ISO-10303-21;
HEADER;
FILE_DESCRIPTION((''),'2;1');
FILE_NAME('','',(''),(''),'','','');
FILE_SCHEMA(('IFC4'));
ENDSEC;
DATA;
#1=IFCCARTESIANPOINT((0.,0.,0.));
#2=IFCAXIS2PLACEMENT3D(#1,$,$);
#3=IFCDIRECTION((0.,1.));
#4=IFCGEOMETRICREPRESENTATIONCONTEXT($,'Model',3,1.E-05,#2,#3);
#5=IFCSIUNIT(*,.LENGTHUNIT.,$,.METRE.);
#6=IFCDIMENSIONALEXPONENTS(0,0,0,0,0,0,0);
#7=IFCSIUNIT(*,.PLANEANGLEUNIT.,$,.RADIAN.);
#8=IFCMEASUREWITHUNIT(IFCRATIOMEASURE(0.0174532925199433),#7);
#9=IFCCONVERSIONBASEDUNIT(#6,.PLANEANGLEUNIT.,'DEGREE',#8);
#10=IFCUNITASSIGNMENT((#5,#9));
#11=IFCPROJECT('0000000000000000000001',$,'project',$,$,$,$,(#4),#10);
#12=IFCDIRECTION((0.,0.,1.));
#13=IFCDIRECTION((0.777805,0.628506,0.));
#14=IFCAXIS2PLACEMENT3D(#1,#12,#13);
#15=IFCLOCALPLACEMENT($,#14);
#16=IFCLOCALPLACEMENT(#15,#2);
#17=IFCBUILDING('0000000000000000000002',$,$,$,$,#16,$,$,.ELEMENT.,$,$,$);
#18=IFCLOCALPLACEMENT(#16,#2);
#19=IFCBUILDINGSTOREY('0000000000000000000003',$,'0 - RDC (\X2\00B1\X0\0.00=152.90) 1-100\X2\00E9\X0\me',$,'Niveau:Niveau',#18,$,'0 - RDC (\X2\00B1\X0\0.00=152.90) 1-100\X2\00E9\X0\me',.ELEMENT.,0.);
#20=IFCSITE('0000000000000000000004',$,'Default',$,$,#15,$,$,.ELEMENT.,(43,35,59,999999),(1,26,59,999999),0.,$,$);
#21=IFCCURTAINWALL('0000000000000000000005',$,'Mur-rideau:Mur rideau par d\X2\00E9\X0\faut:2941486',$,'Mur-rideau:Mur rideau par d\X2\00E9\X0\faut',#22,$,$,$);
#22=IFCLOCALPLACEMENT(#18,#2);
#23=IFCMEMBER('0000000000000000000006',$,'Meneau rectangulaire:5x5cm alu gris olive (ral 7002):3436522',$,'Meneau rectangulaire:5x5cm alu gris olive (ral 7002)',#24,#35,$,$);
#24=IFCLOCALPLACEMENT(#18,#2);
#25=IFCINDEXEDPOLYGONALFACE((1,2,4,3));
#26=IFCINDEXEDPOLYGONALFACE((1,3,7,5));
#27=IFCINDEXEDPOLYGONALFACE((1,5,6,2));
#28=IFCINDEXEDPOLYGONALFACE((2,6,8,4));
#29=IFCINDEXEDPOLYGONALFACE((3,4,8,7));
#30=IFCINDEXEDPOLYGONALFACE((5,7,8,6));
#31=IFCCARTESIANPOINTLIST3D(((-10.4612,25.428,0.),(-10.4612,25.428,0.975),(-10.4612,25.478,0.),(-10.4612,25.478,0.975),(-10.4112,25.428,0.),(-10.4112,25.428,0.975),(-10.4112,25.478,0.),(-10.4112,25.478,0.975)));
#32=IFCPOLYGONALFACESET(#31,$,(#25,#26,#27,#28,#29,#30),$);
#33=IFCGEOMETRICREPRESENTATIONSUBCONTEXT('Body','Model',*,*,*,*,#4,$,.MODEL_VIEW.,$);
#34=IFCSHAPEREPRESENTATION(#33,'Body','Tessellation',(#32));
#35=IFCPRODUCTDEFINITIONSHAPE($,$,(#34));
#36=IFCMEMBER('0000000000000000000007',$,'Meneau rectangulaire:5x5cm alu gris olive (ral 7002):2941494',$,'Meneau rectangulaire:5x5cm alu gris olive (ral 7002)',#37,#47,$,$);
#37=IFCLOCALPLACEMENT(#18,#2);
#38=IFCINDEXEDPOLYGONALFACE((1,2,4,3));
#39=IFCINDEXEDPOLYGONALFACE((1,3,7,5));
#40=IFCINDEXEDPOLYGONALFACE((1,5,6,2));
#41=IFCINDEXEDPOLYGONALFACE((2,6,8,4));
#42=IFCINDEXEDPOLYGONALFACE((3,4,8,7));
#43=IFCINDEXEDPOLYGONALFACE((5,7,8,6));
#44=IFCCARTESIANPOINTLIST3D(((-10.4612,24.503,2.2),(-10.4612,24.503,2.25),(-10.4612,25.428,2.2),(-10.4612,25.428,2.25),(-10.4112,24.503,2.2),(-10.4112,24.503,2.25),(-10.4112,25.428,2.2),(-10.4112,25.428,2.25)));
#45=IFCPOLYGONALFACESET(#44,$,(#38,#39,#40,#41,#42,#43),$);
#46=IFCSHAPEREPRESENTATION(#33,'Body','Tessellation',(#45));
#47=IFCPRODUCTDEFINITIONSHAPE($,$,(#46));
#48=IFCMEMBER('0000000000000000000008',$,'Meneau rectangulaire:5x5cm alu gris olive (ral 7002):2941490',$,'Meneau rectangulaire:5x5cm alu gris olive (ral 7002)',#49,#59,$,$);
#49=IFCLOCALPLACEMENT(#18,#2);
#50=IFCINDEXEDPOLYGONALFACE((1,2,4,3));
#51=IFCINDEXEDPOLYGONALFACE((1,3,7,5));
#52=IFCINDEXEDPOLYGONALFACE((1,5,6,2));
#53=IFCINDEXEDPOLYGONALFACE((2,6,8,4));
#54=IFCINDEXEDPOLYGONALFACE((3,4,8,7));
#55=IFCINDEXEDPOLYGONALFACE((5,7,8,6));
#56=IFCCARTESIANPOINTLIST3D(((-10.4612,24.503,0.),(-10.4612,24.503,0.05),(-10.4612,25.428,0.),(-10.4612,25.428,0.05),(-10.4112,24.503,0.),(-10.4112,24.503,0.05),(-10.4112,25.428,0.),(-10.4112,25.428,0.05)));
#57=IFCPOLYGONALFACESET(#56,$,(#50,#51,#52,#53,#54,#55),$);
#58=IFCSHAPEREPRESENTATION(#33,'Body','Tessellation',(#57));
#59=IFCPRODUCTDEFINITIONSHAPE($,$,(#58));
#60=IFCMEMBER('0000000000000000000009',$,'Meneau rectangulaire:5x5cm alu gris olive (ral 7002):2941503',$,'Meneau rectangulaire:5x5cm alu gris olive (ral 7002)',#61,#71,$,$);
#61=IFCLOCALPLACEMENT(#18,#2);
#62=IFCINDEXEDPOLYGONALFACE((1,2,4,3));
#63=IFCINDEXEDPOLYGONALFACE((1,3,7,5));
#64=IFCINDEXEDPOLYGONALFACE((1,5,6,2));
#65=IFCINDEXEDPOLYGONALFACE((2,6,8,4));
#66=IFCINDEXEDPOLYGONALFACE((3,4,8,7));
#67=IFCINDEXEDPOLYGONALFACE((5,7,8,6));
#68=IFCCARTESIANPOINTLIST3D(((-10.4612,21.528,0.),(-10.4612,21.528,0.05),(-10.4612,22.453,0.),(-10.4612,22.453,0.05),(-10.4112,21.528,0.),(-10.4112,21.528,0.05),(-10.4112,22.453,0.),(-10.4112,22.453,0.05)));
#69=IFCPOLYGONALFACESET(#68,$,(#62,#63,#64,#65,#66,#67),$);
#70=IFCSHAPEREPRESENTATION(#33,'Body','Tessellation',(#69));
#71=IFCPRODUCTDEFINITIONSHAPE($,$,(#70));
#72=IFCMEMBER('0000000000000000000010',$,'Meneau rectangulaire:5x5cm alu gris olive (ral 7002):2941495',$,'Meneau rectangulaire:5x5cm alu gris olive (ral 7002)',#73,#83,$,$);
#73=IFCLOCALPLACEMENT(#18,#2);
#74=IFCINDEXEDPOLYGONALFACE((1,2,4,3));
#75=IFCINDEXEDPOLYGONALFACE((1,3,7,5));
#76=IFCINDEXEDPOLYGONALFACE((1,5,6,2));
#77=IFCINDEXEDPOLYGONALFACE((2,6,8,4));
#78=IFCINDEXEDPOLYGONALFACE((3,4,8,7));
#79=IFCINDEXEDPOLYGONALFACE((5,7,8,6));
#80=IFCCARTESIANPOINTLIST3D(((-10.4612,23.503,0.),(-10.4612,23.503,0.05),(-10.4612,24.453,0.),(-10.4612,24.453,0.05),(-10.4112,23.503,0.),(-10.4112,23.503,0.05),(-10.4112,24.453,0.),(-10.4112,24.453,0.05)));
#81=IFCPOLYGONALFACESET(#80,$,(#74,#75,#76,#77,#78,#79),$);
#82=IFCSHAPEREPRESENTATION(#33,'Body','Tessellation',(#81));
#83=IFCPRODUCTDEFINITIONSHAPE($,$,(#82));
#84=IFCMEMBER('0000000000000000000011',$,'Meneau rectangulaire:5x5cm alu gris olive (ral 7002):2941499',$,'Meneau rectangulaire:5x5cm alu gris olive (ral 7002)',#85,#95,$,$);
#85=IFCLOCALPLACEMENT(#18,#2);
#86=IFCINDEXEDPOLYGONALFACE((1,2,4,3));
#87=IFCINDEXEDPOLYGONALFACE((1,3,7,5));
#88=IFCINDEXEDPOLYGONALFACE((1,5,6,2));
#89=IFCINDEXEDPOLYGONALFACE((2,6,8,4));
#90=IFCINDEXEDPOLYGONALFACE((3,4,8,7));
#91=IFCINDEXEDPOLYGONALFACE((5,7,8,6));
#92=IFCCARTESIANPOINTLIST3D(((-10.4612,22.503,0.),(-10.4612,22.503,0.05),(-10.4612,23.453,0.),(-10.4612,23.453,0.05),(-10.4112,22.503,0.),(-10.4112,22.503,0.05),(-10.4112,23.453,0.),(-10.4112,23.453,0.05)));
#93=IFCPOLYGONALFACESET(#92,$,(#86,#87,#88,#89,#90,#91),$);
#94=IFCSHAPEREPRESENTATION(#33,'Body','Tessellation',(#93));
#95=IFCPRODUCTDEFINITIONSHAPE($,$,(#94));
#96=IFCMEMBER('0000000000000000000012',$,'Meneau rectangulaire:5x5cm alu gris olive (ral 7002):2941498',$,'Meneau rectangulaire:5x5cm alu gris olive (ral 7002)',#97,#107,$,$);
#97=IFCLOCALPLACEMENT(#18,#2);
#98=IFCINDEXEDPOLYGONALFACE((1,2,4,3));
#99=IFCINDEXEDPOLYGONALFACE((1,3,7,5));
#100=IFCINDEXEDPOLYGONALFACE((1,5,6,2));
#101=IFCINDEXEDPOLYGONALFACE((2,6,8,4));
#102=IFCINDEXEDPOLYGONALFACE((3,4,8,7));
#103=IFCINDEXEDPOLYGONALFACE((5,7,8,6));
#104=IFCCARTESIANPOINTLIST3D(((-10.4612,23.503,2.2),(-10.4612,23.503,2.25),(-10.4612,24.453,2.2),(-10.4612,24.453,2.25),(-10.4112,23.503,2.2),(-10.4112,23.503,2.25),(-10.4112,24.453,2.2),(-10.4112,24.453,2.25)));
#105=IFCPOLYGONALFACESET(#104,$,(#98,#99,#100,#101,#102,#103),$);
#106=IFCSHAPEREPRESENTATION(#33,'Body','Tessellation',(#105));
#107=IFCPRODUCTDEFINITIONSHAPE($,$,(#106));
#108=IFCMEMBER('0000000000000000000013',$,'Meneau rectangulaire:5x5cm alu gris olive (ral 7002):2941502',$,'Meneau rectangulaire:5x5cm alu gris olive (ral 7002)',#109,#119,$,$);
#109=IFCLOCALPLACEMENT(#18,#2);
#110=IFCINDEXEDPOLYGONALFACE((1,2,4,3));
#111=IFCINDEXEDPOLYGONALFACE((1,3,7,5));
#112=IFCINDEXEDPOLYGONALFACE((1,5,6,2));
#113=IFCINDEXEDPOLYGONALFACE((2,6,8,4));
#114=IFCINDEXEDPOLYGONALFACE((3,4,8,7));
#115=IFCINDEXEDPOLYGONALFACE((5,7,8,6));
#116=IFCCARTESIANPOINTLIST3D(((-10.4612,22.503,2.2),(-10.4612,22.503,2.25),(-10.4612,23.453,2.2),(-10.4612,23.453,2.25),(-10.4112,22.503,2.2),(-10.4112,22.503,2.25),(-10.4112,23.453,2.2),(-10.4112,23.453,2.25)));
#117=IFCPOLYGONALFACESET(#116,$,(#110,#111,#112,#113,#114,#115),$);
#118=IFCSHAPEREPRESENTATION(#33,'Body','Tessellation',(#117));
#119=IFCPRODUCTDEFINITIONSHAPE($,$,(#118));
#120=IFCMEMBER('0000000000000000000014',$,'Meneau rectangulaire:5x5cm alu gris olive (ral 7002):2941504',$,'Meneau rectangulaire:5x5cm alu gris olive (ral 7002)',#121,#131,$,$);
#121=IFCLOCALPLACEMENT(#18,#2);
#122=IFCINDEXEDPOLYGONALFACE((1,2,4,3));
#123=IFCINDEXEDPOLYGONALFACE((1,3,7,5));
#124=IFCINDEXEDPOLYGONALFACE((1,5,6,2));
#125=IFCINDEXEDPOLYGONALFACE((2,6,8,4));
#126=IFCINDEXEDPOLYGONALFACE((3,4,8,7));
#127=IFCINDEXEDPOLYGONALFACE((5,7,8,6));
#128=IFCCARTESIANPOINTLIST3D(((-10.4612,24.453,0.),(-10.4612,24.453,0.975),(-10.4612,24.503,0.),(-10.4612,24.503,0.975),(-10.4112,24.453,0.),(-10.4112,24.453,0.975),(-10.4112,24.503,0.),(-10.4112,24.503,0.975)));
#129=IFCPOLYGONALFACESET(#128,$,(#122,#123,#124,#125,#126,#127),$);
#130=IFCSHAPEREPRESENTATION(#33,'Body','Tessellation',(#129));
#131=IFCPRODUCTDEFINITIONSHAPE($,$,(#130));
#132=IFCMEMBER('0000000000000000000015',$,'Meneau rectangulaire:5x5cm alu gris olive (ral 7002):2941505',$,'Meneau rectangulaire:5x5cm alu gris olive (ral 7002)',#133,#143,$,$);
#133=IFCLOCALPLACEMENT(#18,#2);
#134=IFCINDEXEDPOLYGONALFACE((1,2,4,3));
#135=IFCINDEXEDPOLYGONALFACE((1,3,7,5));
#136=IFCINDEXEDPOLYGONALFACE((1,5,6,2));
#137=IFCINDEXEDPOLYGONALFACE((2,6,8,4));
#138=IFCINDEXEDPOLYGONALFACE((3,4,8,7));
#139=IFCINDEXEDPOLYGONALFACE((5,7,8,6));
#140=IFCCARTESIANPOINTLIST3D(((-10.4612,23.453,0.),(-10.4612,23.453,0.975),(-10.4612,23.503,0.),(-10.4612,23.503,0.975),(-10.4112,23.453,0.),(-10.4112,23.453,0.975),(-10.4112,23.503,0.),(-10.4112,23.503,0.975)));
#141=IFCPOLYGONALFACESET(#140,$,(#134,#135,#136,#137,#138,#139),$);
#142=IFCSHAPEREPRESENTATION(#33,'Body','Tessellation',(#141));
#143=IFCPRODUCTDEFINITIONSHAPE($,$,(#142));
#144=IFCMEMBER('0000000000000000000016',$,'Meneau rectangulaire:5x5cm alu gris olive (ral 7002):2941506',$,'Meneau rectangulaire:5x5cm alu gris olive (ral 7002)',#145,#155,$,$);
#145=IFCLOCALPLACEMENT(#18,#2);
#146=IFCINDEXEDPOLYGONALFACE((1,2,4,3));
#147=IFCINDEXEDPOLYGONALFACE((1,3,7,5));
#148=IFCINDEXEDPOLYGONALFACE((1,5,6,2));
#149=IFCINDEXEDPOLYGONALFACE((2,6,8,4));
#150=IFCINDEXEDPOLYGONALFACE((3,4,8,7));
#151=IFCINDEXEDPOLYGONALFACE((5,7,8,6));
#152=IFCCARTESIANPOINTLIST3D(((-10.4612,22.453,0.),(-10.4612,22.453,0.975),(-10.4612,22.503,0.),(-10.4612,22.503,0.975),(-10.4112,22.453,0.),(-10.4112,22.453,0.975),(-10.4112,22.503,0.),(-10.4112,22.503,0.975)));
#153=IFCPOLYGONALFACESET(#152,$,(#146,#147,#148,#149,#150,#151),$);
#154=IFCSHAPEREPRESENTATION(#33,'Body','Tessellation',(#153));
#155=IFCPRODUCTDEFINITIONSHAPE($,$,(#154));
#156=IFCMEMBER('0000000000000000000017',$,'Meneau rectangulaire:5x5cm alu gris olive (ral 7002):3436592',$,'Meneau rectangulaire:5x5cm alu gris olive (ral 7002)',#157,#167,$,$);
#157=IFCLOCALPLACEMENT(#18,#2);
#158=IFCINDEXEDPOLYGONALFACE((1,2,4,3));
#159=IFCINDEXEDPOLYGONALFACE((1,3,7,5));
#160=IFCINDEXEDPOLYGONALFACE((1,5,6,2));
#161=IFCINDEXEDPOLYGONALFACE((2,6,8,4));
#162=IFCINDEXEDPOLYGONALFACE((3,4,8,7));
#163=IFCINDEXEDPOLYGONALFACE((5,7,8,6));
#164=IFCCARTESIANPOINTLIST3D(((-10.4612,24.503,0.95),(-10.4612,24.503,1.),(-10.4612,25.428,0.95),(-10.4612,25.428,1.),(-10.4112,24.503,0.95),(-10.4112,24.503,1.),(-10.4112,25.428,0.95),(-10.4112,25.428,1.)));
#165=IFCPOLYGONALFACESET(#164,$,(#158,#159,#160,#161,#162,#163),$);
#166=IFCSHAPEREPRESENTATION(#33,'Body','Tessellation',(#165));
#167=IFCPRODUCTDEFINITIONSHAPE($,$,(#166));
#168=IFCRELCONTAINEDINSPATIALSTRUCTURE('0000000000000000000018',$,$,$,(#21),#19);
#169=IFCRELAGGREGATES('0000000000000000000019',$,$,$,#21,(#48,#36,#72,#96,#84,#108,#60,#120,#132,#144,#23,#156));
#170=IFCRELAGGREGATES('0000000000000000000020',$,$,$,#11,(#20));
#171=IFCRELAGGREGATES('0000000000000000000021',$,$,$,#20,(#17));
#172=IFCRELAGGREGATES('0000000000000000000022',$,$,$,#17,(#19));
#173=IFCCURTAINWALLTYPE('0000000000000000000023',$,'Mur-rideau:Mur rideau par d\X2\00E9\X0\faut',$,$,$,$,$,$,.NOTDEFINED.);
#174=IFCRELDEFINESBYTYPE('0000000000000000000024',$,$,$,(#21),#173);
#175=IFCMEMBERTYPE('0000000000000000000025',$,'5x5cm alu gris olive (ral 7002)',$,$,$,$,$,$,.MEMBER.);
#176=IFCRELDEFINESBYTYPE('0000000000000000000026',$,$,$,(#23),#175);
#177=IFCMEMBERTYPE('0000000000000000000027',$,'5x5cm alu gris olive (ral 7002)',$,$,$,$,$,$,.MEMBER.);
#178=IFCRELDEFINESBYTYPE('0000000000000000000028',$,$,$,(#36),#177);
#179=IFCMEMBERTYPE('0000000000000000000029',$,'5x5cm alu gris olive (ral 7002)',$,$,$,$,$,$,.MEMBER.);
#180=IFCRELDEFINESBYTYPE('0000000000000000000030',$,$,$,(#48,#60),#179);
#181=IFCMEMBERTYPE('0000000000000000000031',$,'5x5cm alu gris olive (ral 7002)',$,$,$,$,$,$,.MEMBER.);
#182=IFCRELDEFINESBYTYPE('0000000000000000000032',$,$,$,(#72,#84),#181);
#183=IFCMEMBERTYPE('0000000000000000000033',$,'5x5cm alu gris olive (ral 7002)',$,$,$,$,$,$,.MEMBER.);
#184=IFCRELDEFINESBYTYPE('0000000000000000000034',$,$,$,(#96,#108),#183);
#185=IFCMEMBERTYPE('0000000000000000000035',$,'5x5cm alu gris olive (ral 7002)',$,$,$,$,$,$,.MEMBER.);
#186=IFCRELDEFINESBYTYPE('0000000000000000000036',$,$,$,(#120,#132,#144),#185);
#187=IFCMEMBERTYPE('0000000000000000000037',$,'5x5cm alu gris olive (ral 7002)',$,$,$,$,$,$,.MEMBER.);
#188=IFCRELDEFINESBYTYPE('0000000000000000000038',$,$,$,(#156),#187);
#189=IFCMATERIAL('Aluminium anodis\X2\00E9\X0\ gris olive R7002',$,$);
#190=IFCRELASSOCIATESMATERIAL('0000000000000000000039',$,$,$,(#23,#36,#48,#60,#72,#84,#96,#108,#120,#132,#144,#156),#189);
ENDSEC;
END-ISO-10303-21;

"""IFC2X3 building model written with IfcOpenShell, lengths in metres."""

from ifc_helpers import new_model, entity, si_unit, converted_unit, direction, frame, origin, origin_2d_with_axis, place, context, subcontext, project, spatial, rectangle, extrude, source, transform, mapped, material, type_object, type_shapes, element, aggregate, save


model = new_model("IFC2X3")

# Units and contexts
model_context = context("Model", 3, precision=1e-05, world=origin(), true_north=direction((0.0, 1.0)))
body_context = subcontext(model_context, "Body", "Model", "MODEL_VIEW")
ifc_project = project(units=[si_unit("LENGTHUNIT", "METRE"), converted_unit("PLANEANGLEUNIT", "DEGREE", entity("IfcRatioMeasure", 0.0174532925199433), si_unit("PLANEANGLEUNIT", "RADIAN"), dimensions=[0, 0, 0, 0, 0, 0, 0])], contexts=[model_context])

# Site, building, storey
site_placement = place(None, frame((0.0, 0.0, 0.0), z_axis=(0.0, 0.0, 1.0), x_axis=(0.777805, 0.628506, 0.0)))
site = spatial("IfcSite", under=ifc_project, at=site_placement, Name="Default", CompositionType="ELEMENT", RefLatitude=(43, 35, 59, 999999), RefLongitude=(1, 26, 59, 999999), RefElevation=0.0)
building_placement = place(site_placement, origin())
building = spatial("IfcBuilding", under=site, at=building_placement, CompositionType="ELEMENT")
storey_placement = place(building_placement, origin())
storey = spatial("IfcBuildingStorey", under=building, at=storey_placement, Name="0 - RDC (±0.00=152.90) 1-100éme", ObjectType="Niveau:Niveau", LongName="0 - RDC (±0.00=152.90) 1-100éme", CompositionType="ELEMENT", Elevation=0.0)

# Curtain wall, members
curtain_wall_type = type_object("IfcCurtainWallType", Name="Mur-rideau:Mur rideau par défaut", PredefinedType="NOTDEFINED")
curtain_wall_placement = place(storey_placement, origin())
curtain_wall = element("IfcCurtainWall", 1, at=curtain_wall_placement, inside=storey, type_object=curtain_wall_type, Name="Mur-rideau:Mur rideau par défaut:2941486", ObjectType="Mur-rideau:Mur rideau par défaut")
ifc_material_1 = material(Name="Aluminium anodisé gris olive R7002")
member_type_1 = type_object("IfcMemberType", Name="5x5cm alu gris olive (ral 7002)", PredefinedType="MEMBER")
shared_shape_1 = source(origin(), body_context, "Body", "SweptSolid", [
    extrude(rectangle(XDim=0.05, YDim=0.05, at=origin_2d_with_axis()), frame((-0.025, 0.0, -0.975), z_axis=(0.0, 0.0, 1.0), x_axis=(0.0, -1.0, 0.0)), (0.0, 0.0, 1.0), 0.975),
])
type_shapes(member_type_1, [shared_shape_1])
member_1_placement = place(storey_placement, frame((-10.4362, 25.478, 0.975), z_axis=(0.0, 0.0, 1.0), x_axis=(0.0, 1.0, 0.0)))
member_1 = element("IfcMember", 2, at=member_1_placement, type_object=member_type_1, material=ifc_material_1, Name="Meneau rectangulaire:5x5cm alu gris olive (ral 7002):3436522", ObjectType="Meneau rectangulaire:5x5cm alu gris olive (ral 7002)", context=body_context, shape_type="MappedRepresentation", body=[
    mapped(shared_shape_1, transform((0.0, 0.0, 0.0), scale=1.0)),
])
member_type_2 = type_object("IfcMemberType", Name="5x5cm alu gris olive (ral 7002)", PredefinedType="MEMBER")
shared_shape_2 = source(origin(), body_context, "Body", "SweptSolid", [
    extrude(rectangle(XDim=0.05, YDim=0.05, at=origin_2d_with_axis()), frame((-0.025, 0.0, -0.925), z_axis=(0.0, 0.0, 1.0), x_axis=(0.0, -1.0, 0.0)), (0.0, 0.0, 1.0), 0.925),
])
type_shapes(member_type_2, [shared_shape_2])
member_2_placement = place(storey_placement, frame((-10.4362, 24.503, 2.25), z_axis=(0.0, -1.0, 0.0), x_axis=(0.0, 0.0, 1.0)))
member_2 = element("IfcMember", 3, at=member_2_placement, type_object=member_type_2, material=ifc_material_1, Name="Meneau rectangulaire:5x5cm alu gris olive (ral 7002):2941494", ObjectType="Meneau rectangulaire:5x5cm alu gris olive (ral 7002)", context=body_context, shape_type="MappedRepresentation", body=[
    mapped(shared_shape_2, transform((0.0, 0.0, 0.0), scale=1.0)),
])
member_type_3 = type_object("IfcMemberType", Name="5x5cm alu gris olive (ral 7002)", PredefinedType="MEMBER")
shared_shape_3 = source(origin(), body_context, "Body", "SweptSolid", [
    extrude(rectangle(XDim=0.05, YDim=0.05, at=origin_2d_with_axis()), frame((-0.025, 0.0, -0.925), z_axis=(0.0, 0.0, 1.0), x_axis=(0.0, -1.0, 0.0)), (0.0, 0.0, 1.0), 0.925),
])
type_shapes(member_type_3, [shared_shape_3])
member_3_placement = place(storey_placement, frame((-10.4362, 25.428, 0.0), z_axis=(0.0, 1.0, 0.0), x_axis=(0.0, 0.0, -1.0)))
member_3 = element("IfcMember", 4, at=member_3_placement, type_object=member_type_3, material=ifc_material_1, Name="Meneau rectangulaire:5x5cm alu gris olive (ral 7002):2941490", ObjectType="Meneau rectangulaire:5x5cm alu gris olive (ral 7002)", context=body_context, shape_type="MappedRepresentation", body=[
    mapped(shared_shape_3, transform((0.0, 0.0, 0.0), scale=1.0)),
])
member_4_placement = place(storey_placement, frame((-10.4362, 22.453, 0.0), z_axis=(0.0, 1.0, 0.0), x_axis=(0.0, 0.0, -1.0)))
member_4 = element("IfcMember", 5, at=member_4_placement, type_object=member_type_3, material=ifc_material_1, Name="Meneau rectangulaire:5x5cm alu gris olive (ral 7002):2941503", ObjectType="Meneau rectangulaire:5x5cm alu gris olive (ral 7002)", context=body_context, shape_type="MappedRepresentation", body=[
    mapped(shared_shape_3, transform((0.0, 0.0, 0.0), scale=1.0)),
])
member_type_4 = type_object("IfcMemberType", Name="5x5cm alu gris olive (ral 7002)", PredefinedType="MEMBER")
shared_shape_4 = source(origin(), body_context, "Body", "SweptSolid", [
    extrude(rectangle(XDim=0.05, YDim=0.05, at=origin_2d_with_axis()), frame((-0.025, 0.0, -0.95), z_axis=(0.0, 0.0, 1.0), x_axis=(0.0, -1.0, 0.0)), (0.0, 0.0, 1.0), 0.95),
])
type_shapes(member_type_4, [shared_shape_4])
member_5_placement = place(storey_placement, frame((-10.4362, 24.453, 0.0), z_axis=(0.0, 1.0, 0.0), x_axis=(0.0, 0.0, -1.0)))
member_5 = element("IfcMember", 6, at=member_5_placement, type_object=member_type_4, material=ifc_material_1, Name="Meneau rectangulaire:5x5cm alu gris olive (ral 7002):2941495", ObjectType="Meneau rectangulaire:5x5cm alu gris olive (ral 7002)", context=body_context, shape_type="MappedRepresentation", body=[
    mapped(shared_shape_4, transform((0.0, 0.0, 0.0), scale=1.0)),
])
member_6_placement = place(storey_placement, frame((-10.4362, 23.453, 0.0), z_axis=(0.0, 1.0, 0.0), x_axis=(0.0, 0.0, -1.0)))
member_6 = element("IfcMember", 7, at=member_6_placement, type_object=member_type_4, material=ifc_material_1, Name="Meneau rectangulaire:5x5cm alu gris olive (ral 7002):2941499", ObjectType="Meneau rectangulaire:5x5cm alu gris olive (ral 7002)", context=body_context, shape_type="MappedRepresentation", body=[
    mapped(shared_shape_4, transform((0.0, 0.0, 0.0), scale=1.0)),
])
member_type_5 = type_object("IfcMemberType", Name="5x5cm alu gris olive (ral 7002)", PredefinedType="MEMBER")
shared_shape_5 = source(origin(), body_context, "Body", "SweptSolid", [
    extrude(rectangle(XDim=0.05, YDim=0.05, at=origin_2d_with_axis()), frame((-0.025, 0.0, -0.95), z_axis=(0.0, 0.0, 1.0), x_axis=(0.0, -1.0, 0.0)), (0.0, 0.0, 1.0), 0.95),
])
type_shapes(member_type_5, [shared_shape_5])
member_7_placement = place(storey_placement, frame((-10.4362, 23.503, 2.25), z_axis=(0.0, -1.0, 0.0), x_axis=(0.0, 0.0, 1.0)))
member_7 = element("IfcMember", 8, at=member_7_placement, type_object=member_type_5, material=ifc_material_1, Name="Meneau rectangulaire:5x5cm alu gris olive (ral 7002):2941498", ObjectType="Meneau rectangulaire:5x5cm alu gris olive (ral 7002)", context=body_context, shape_type="MappedRepresentation", body=[
    mapped(shared_shape_5, transform((0.0, 0.0, 0.0), scale=1.0)),
])
member_8_placement = place(storey_placement, frame((-10.4362, 22.503, 2.25), z_axis=(0.0, -1.0, 0.0), x_axis=(0.0, 0.0, 1.0)))
member_8 = element("IfcMember", 9, at=member_8_placement, type_object=member_type_5, material=ifc_material_1, Name="Meneau rectangulaire:5x5cm alu gris olive (ral 7002):2941502", ObjectType="Meneau rectangulaire:5x5cm alu gris olive (ral 7002)", context=body_context, shape_type="MappedRepresentation", body=[
    mapped(shared_shape_5, transform((0.0, 0.0, 0.0), scale=1.0)),
])
member_type_6 = type_object("IfcMemberType", Name="5x5cm alu gris olive (ral 7002)", PredefinedType="MEMBER")
shared_shape_6 = source(origin(), body_context, "Body", "SweptSolid", [
    extrude(rectangle(XDim=0.05, YDim=0.05, at=origin_2d_with_axis()), frame((0.0, 0.0, -0.975), z_axis=(0.0, 0.0, 1.0), x_axis=(0.0, -1.0, 0.0)), (0.0, 0.0, 1.0), 0.975),
])
type_shapes(member_type_6, [shared_shape_6])
member_9_placement = place(storey_placement, frame((-10.4362, 24.478, 0.0), z_axis=(0.0, 0.0, -1.0), x_axis=(0.0, -1.0, 0.0)))
member_9 = element("IfcMember", 10, at=member_9_placement, type_object=member_type_6, material=ifc_material_1, Name="Meneau rectangulaire:5x5cm alu gris olive (ral 7002):2941504", ObjectType="Meneau rectangulaire:5x5cm alu gris olive (ral 7002)", context=body_context, shape_type="MappedRepresentation", body=[
    mapped(shared_shape_6, transform((0.0, 0.0, 0.0), scale=1.0)),
])
member_10_placement = place(storey_placement, frame((-10.4362, 23.478, 0.0), z_axis=(0.0, 0.0, -1.0), x_axis=(0.0, -1.0, 0.0)))
member_10 = element("IfcMember", 11, at=member_10_placement, type_object=member_type_6, material=ifc_material_1, Name="Meneau rectangulaire:5x5cm alu gris olive (ral 7002):2941505", ObjectType="Meneau rectangulaire:5x5cm alu gris olive (ral 7002)", context=body_context, shape_type="MappedRepresentation", body=[
    mapped(shared_shape_6, transform((0.0, 0.0, 0.0), scale=1.0)),
])
member_11_placement = place(storey_placement, frame((-10.4362, 22.478, 0.0), z_axis=(0.0, 0.0, -1.0), x_axis=(0.0, -1.0, 0.0)))
member_11 = element("IfcMember", 12, at=member_11_placement, type_object=member_type_6, material=ifc_material_1, Name="Meneau rectangulaire:5x5cm alu gris olive (ral 7002):2941506", ObjectType="Meneau rectangulaire:5x5cm alu gris olive (ral 7002)", context=body_context, shape_type="MappedRepresentation", body=[
    mapped(shared_shape_6, transform((0.0, 0.0, 0.0), scale=1.0)),
])
member_type_7 = type_object("IfcMemberType", Name="5x5cm alu gris olive (ral 7002)", PredefinedType="MEMBER")
shared_shape_7 = source(origin(), body_context, "Body", "SweptSolid", [
    extrude(rectangle(XDim=0.05, YDim=0.05, at=origin_2d_with_axis()), frame((0.0, 0.0, -0.925), z_axis=(0.0, 0.0, 1.0), x_axis=(0.0, -1.0, 0.0)), (0.0, 0.0, 1.0), 0.925),
])
type_shapes(member_type_7, [shared_shape_7])
member_12_placement = place(storey_placement, frame((-10.4362, 24.503, 0.975), z_axis=(0.0, -1.0, 0.0), x_axis=(0.0, 0.0, 1.0)))
member_12 = element("IfcMember", 13, at=member_12_placement, type_object=member_type_7, material=ifc_material_1, Name="Meneau rectangulaire:5x5cm alu gris olive (ral 7002):3436592", ObjectType="Meneau rectangulaire:5x5cm alu gris olive (ral 7002)", context=body_context, shape_type="MappedRepresentation", body=[
    mapped(shared_shape_7, transform((0.0, 0.0, 0.0), scale=1.0)),
])
aggregate(curtain_wall, [member_3, member_2, member_5, member_7, member_6, member_8, member_4, member_9, member_10, member_11, member_1, member_12])

save(model, "model.ifc")
